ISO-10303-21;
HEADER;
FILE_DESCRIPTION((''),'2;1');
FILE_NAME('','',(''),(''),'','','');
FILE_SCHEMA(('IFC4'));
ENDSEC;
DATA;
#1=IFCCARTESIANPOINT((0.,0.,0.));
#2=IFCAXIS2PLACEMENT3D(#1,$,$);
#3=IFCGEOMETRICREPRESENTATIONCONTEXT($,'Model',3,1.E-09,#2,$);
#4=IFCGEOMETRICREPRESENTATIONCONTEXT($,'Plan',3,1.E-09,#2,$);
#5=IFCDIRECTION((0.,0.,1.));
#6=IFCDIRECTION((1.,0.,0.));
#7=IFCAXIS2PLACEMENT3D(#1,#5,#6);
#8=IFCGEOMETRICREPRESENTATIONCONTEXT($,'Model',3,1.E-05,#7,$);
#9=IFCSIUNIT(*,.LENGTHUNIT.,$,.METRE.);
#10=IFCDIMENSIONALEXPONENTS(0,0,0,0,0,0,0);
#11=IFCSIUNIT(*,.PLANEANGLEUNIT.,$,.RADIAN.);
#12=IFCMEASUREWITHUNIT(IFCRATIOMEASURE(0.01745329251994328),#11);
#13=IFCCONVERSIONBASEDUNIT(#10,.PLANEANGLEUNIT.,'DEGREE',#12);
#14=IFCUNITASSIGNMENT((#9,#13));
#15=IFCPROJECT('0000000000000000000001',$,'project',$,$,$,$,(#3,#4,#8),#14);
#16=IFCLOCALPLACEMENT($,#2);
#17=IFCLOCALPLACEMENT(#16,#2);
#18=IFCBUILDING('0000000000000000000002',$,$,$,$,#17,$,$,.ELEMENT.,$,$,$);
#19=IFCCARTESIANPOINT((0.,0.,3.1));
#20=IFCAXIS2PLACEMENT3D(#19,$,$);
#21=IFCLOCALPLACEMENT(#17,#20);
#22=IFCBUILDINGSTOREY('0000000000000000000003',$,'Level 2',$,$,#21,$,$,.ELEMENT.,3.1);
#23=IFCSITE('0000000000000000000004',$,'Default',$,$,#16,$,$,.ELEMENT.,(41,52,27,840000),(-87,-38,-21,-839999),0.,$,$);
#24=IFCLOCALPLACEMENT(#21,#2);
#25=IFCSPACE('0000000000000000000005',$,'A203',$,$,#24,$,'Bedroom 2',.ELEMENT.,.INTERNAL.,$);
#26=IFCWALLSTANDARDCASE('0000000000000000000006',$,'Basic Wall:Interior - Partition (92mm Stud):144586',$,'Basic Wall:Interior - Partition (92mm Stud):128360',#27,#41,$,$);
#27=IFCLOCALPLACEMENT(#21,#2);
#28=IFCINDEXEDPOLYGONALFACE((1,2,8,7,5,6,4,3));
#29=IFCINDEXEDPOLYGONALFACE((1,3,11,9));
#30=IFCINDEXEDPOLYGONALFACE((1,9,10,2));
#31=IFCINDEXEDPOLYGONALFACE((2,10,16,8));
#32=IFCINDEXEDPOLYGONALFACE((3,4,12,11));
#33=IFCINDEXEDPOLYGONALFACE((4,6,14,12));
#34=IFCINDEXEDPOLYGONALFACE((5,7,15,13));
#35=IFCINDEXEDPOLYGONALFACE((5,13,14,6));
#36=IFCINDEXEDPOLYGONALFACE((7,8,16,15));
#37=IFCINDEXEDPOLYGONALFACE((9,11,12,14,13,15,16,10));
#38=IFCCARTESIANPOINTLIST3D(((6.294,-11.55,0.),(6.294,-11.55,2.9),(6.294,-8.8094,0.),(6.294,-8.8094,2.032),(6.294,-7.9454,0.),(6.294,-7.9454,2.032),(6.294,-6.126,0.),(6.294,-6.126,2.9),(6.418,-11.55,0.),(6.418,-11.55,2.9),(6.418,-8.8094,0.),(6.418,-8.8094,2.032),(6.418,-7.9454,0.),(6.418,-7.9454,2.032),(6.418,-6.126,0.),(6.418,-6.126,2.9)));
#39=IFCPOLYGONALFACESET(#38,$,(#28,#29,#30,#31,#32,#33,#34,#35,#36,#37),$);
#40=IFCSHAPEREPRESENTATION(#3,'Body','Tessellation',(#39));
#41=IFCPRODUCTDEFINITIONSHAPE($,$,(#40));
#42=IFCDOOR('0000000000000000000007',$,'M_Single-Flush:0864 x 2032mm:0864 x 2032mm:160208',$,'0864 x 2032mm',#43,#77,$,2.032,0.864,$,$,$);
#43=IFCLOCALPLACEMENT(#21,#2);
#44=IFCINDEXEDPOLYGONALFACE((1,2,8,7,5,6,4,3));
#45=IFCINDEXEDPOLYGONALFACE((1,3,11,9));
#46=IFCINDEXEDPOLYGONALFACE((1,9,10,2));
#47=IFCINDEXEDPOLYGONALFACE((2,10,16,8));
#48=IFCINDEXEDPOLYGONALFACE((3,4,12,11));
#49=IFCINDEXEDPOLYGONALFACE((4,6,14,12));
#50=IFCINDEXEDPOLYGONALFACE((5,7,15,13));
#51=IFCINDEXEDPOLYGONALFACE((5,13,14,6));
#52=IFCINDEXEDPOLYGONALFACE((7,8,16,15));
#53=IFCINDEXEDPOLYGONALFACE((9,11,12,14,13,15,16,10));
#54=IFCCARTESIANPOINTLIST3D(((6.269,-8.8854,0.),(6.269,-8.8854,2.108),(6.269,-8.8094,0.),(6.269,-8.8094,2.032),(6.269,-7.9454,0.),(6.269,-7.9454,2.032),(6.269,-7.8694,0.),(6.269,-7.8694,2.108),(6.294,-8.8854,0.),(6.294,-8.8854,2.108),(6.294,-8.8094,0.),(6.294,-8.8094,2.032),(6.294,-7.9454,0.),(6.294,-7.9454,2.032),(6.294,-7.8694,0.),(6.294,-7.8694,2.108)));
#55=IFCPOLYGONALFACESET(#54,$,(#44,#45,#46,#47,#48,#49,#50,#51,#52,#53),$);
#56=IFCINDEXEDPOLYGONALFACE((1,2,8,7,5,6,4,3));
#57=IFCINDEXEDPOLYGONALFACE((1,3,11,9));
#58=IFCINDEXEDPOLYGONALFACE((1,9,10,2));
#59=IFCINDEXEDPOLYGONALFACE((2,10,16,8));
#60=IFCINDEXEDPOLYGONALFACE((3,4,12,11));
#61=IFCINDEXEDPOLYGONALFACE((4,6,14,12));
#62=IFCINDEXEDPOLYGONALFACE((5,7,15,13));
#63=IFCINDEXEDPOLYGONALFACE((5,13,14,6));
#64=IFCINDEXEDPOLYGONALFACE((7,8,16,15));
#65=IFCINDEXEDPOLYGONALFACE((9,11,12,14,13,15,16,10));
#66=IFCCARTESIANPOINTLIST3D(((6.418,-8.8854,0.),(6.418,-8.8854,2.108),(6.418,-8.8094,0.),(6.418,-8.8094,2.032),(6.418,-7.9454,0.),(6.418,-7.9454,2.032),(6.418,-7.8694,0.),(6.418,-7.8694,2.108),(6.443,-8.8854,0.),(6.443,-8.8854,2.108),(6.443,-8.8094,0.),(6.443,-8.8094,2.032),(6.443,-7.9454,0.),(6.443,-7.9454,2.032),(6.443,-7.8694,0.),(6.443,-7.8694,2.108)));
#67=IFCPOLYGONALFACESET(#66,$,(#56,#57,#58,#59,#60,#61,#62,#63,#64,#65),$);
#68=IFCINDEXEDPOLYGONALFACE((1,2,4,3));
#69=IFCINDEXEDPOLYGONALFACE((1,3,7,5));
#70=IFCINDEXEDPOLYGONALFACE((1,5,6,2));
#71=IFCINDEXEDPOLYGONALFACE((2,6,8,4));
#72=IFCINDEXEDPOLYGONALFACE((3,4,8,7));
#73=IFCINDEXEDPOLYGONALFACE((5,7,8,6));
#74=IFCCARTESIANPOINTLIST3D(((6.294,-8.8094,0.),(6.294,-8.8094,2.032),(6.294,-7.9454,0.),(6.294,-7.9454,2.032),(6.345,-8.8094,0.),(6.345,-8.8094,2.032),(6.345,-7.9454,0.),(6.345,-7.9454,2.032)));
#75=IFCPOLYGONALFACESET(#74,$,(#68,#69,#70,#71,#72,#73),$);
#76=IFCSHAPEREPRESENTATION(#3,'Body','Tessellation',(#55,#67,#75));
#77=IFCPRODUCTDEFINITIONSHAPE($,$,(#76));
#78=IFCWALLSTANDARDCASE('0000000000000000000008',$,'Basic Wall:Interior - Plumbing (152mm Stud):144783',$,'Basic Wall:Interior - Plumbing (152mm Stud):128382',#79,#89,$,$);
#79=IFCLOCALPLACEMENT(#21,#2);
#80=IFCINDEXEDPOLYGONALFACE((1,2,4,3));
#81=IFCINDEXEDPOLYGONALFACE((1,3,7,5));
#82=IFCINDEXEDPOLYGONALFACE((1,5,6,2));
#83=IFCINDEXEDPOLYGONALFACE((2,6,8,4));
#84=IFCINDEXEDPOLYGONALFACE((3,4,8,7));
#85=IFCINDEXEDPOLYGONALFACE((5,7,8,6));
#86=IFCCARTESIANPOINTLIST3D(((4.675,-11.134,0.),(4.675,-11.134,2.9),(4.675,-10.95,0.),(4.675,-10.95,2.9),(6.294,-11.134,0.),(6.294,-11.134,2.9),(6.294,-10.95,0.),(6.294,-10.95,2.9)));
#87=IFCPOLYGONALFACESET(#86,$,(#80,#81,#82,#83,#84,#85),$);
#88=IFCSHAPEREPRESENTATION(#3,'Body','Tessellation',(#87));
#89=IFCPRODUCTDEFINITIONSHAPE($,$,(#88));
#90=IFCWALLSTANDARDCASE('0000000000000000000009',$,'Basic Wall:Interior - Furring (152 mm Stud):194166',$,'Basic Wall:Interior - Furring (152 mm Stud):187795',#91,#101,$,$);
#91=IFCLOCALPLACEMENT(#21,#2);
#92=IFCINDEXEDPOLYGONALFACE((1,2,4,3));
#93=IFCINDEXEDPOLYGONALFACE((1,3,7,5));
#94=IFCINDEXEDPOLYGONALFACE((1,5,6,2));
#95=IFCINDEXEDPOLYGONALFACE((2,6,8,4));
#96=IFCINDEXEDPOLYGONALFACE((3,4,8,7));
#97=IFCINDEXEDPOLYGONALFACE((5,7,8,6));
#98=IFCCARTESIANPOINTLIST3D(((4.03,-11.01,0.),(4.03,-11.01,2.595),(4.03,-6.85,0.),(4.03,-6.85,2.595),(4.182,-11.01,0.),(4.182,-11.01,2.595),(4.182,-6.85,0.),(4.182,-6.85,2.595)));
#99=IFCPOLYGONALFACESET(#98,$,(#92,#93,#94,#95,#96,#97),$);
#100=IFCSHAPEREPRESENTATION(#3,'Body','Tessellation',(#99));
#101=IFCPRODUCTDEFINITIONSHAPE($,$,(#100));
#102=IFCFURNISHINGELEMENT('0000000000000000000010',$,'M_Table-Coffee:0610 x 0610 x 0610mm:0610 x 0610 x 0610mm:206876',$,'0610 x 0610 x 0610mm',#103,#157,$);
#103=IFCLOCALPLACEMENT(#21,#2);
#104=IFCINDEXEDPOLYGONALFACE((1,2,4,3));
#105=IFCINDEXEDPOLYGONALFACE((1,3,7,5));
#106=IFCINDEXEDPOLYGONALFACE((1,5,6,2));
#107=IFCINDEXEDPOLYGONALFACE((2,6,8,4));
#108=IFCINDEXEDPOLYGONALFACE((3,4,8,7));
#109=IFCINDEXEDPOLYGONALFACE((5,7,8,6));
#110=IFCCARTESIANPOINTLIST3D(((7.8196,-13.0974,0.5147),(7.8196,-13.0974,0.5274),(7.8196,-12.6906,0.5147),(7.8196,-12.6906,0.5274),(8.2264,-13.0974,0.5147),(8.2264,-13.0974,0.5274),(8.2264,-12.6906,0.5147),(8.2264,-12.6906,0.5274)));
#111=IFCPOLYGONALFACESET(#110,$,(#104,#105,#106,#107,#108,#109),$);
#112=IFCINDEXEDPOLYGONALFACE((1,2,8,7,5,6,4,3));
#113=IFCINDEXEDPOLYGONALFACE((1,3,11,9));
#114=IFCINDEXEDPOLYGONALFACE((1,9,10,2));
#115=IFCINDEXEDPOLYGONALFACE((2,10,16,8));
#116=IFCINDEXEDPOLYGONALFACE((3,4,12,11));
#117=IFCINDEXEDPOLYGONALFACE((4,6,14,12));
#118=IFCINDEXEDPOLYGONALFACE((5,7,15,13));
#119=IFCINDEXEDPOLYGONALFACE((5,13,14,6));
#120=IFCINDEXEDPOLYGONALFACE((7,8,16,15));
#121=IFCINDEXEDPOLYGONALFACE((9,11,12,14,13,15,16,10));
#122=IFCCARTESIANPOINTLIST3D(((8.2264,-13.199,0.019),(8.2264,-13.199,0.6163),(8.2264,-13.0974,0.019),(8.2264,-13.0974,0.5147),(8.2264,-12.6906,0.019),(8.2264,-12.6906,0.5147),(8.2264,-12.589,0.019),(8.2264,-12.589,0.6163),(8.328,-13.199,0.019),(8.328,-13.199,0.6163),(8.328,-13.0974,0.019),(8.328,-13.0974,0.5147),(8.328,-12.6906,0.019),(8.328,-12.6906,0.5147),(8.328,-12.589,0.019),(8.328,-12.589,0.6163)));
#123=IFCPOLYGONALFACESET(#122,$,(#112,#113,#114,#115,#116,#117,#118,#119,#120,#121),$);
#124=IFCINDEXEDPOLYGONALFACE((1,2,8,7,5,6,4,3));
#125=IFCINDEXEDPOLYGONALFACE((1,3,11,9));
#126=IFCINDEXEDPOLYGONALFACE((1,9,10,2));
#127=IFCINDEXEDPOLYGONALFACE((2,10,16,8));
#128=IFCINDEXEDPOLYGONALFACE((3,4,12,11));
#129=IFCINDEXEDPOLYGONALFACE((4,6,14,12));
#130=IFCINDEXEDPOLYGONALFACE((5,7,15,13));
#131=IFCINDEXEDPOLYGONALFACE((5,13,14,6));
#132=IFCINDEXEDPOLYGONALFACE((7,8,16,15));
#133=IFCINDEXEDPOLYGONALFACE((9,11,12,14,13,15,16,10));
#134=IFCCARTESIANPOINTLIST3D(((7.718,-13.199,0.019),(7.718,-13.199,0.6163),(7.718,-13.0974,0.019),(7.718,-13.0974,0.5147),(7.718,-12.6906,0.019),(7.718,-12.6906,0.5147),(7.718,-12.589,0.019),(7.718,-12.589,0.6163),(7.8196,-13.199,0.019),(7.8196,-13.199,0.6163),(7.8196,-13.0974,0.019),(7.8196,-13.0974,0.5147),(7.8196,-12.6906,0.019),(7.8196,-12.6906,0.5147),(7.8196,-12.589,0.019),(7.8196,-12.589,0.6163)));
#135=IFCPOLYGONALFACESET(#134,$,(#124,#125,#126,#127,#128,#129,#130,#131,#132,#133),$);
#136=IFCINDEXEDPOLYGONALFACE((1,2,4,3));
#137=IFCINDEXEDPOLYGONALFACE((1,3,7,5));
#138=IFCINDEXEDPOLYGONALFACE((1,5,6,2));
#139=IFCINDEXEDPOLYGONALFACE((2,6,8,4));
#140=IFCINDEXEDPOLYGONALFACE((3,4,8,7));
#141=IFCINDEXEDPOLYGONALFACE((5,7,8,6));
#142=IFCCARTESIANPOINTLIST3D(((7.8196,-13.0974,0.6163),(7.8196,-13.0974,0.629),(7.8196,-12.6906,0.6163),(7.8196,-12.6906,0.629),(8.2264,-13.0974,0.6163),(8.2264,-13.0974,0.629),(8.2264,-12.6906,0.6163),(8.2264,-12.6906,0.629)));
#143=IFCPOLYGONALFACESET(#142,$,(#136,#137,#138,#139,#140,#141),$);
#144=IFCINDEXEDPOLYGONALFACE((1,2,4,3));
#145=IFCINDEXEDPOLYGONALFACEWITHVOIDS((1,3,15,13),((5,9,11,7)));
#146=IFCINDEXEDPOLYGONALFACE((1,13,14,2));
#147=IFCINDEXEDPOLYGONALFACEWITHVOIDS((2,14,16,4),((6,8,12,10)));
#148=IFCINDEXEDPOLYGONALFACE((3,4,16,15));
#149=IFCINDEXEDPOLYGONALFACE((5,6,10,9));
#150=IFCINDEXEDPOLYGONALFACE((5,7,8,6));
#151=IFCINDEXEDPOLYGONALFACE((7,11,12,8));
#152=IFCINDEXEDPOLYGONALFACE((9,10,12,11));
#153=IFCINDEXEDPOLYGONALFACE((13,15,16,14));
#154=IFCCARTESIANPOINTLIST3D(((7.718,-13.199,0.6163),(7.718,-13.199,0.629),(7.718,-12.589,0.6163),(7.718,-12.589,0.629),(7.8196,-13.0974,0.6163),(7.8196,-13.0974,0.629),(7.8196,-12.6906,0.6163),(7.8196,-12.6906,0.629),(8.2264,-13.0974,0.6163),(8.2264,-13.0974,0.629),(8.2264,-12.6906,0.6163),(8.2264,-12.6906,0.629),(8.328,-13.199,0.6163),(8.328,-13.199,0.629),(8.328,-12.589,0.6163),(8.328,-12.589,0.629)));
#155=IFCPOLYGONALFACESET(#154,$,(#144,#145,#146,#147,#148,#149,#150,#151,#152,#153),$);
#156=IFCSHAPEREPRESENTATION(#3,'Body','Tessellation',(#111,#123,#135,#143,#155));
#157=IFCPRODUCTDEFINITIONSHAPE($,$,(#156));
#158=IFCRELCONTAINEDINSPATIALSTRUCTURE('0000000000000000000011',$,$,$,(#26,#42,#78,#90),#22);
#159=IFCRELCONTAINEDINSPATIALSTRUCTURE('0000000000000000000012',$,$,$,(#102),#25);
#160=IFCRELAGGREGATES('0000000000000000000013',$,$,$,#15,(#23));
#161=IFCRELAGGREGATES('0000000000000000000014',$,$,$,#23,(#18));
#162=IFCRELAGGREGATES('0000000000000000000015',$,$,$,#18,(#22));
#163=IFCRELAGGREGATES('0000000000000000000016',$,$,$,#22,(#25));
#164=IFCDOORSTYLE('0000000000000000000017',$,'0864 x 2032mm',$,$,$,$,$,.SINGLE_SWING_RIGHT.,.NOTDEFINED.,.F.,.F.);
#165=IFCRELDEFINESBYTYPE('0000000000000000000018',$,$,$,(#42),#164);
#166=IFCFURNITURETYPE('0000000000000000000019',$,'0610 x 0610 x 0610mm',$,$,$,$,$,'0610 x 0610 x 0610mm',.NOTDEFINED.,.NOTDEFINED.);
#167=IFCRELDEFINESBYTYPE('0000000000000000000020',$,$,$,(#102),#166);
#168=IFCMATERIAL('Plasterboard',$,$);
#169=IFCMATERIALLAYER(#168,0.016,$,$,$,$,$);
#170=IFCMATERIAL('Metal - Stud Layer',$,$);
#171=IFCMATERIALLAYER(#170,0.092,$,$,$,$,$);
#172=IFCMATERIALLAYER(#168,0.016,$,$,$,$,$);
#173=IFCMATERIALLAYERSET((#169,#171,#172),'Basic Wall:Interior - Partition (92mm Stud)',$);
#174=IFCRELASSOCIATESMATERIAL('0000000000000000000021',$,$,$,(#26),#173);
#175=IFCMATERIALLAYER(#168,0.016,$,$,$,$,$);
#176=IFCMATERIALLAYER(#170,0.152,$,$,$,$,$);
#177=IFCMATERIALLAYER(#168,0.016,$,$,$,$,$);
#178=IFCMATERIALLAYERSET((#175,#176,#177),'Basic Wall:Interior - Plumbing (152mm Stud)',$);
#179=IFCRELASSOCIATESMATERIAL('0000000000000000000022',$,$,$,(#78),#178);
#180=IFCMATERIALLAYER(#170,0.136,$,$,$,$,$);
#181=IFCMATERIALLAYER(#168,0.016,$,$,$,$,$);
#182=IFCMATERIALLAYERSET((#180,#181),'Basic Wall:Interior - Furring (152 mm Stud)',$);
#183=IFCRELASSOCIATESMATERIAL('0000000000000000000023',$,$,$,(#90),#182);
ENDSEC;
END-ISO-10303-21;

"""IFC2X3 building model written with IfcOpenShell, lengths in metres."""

from ifc_helpers import new_model, entity, si_unit, converted_unit, frame, frame_2d, origin, origin_with_axes, origin_2d_with_axis, place, context, project, spatial, polyline, rectangle, outline, extrude, source, transform, mapped, material, layer, layer_set, layer_usage, type_object, type_shapes, element, fill, save


model = new_model("IFC2X3")

# Units and contexts
model_context_1 = context("Model", 3, precision=1e-09, world=origin())
plan_context = context("Plan", 3, precision=1e-09, world=origin())
model_context_2 = context("Model", 3, precision=1e-05, world=origin_with_axes())
ifc_project = project(units=[si_unit("LENGTHUNIT", "METRE"), converted_unit("PLANEANGLEUNIT", "DEGREE", entity("IfcRatioMeasure", 0.01745329251994328), si_unit("PLANEANGLEUNIT", "RADIAN"), dimensions=[0, 0, 0, 0, 0, 0, 0])], contexts=[model_context_1, plan_context, model_context_2])

# Site, building, storey
site_placement = place(None, origin())
site = spatial("IfcSite", under=ifc_project, at=site_placement, Name="Default", CompositionType="ELEMENT", RefLatitude=(41, 52, 27, 840000), RefLongitude=(-87, -38, -21, -839999), RefElevation=0.0)
building_placement = place(site_placement, origin())
building = spatial("IfcBuilding", under=site, at=building_placement, CompositionType="ELEMENT")
storey_placement = place(building_placement, frame((0.0, 0.0, 3.1)))
storey = spatial("IfcBuildingStorey", under=building, at=storey_placement, Name="Level 2", CompositionType="ELEMENT", Elevation=3.1)

# Shared definitions
ifc_material_1 = material(Name="Metal - Stud Layer")
ifc_material_2 = material(Name="Plasterboard")

# Shared definitions
ifc_layer_1 = layer(ifc_material_2, 0.016)
ifc_layer_2 = layer(ifc_material_1, 0.092)
ifc_layer_3 = layer(ifc_material_2, 0.016)
ifc_layer_set_1 = layer_set([ifc_layer_1, ifc_layer_2, ifc_layer_3], Name="Basic Wall:Interior - Partition (92mm Stud)")

# Wall, opening, door
ifc_layer_usage_1 = layer_usage(ifc_layer_set_1, "AXIS2", "NEGATIVE", 0.062)
wall_1_placement = place(storey_placement, frame((6.356, -11.55, 0.0), z_axis=(0.0, 0.0, 1.0), x_axis=(0.0, 1.0, 0.0)))
wall_1 = element("IfcWallStandardCase", 1, at=wall_1_placement, inside=storey, material=ifc_layer_usage_1, Name="Basic Wall:Interior - Partition (92mm Stud):144586", ObjectType="Basic Wall:Interior - Partition (92mm Stud):128360", context=model_context_1, shape_type="SweptSolid", body=[
    extrude(rectangle(XDim=5.424, YDim=0.124, at=frame_2d((2.712, 0.0), x_axis=(-1.0, 0.0))), origin(), (0.0, 0.0, 1.0), 2.9),
])
opening_1_placement = place(wall_1_placement, frame((2.7406, -0.062, 0.0)))
opening_1 = element("IfcOpeningElement", 2, at=opening_1_placement, cuts=wall_1, ObjectType="Opening", context=model_context_1, shape_type="SweptSolid", body=[
    extrude(rectangle(XDim=0.864, YDim=2.032, at=frame_2d((1.016, 0.432), x_axis=(0.0, 1.0))), frame((0.0, 0.0, 0.0), z_axis=(0.0, 1.0, 0.0), x_axis=(0.0, 0.0, 1.0)), (0.0, 0.0, 1.0), 0.124),
])
door_style = type_object("IfcDoorStyle", Name="0864 x 2032mm", ConstructionType="NOTDEFINED", OperationType="SINGLE_SWING_RIGHT", ParameterTakesPrecedence=False, Sizeable=False)
shared_shape_1 = source(origin(), model_context_1, "Body", "SweptSolid", [
    extrude(outline(polyline([(-0.508, -1.073), (0.508, -1.073), (0.508, 1.035), (0.432, 1.035), (0.432, -0.997), (-0.432, -0.997), (-0.432, 1.035), (-0.508, 1.035), (-0.508, -1.073)])), frame((0.432, 0.124, 1.035), z_axis=(0.0, 1.0, 0.0), x_axis=(1.0, 0.0, 0.0)), (0.0, 0.0, 1.0), 0.025),
    extrude(outline(polyline([(-1.073, -0.508), (1.035, -0.508), (1.035, -0.432), (-0.997, -0.432), (-0.997, 0.432), (1.035, 0.432), (1.035, 0.508), (-1.073, 0.508), (-1.073, -0.508)])), frame((0.432, -0.025, 1.035), z_axis=(0.0, 1.0, 0.0), x_axis=(0.0, 0.0, -1.0)), (0.0, 0.0, 1.0), 0.025),
    extrude(rectangle(XDim=0.051, YDim=0.864, at=origin_2d_with_axis()), frame((0.432, 0.0985, 0.0), z_axis=(0.0, 0.0, 1.0), x_axis=(0.0, 1.0, 0.0)), (0.0, 0.0, 1.0), 2.032),
])
type_shapes(door_style, [shared_shape_1])
door_placement = place(opening_1_placement, origin())
door = element("IfcDoor", 3, at=door_placement, inside=storey, type_object=door_style, Name="M_Single-Flush:0864 x 2032mm:0864 x 2032mm:160208", ObjectType="0864 x 2032mm", OverallHeight=2.032, OverallWidth=0.864, context=model_context_1, shape_type="MappedRepresentation", body=[
    mapped(shared_shape_1, transform((0.0, 0.0, 0.0), scale=1.0)),
])
fill(opening_1, door)

# Walls
ifc_layer_4 = layer(ifc_material_2, 0.016)
ifc_layer_5 = layer(ifc_material_1, 0.152)
ifc_layer_6 = layer(ifc_material_2, 0.016)
ifc_layer_set_2 = layer_set([ifc_layer_4, ifc_layer_5, ifc_layer_6], Name="Basic Wall:Interior - Plumbing (152mm Stud)")
ifc_layer_usage_2 = layer_usage(ifc_layer_set_2, "AXIS2", "NEGATIVE", 0.092)
wall_2_placement = place(storey_placement, frame((6.294, -11.042, 0.0), z_axis=(0.0, 0.0, 1.0), x_axis=(-1.0, 0.0, 0.0)))
element("IfcWallStandardCase", 4, at=wall_2_placement, inside=storey, material=ifc_layer_usage_2, Name="Basic Wall:Interior - Plumbing (152mm Stud):144783", ObjectType="Basic Wall:Interior - Plumbing (152mm Stud):128382", context=model_context_1, shape_type="SweptSolid", body=[
    extrude(rectangle(XDim=1.619, YDim=0.184, at=frame_2d((0.8095, 0.0), x_axis=(-1.0, 0.0))), origin(), (0.0, 0.0, 1.0), 2.9),
])
ifc_layer_7 = layer(ifc_material_1, 0.136)
ifc_layer_8 = layer(ifc_material_2, 0.016)
ifc_layer_set_3 = layer_set([ifc_layer_7, ifc_layer_8], Name="Basic Wall:Interior - Furring (152 mm Stud)")
ifc_layer_usage_3 = layer_usage(ifc_layer_set_3, "AXIS2", "POSITIVE", -0.076)
wall_3_placement = place(storey_placement, frame((4.106, -11.01, 0.0), z_axis=(0.0, 0.0, 1.0), x_axis=(0.0, 1.0, 0.0)))
element("IfcWallStandardCase", 5, at=wall_3_placement, inside=storey, material=ifc_layer_usage_3, Name="Basic Wall:Interior - Furring (152 mm Stud):194166", ObjectType="Basic Wall:Interior - Furring (152 mm Stud):187795", context=model_context_1, shape_type="SweptSolid", body=[
    extrude(rectangle(XDim=4.16, YDim=0.152, at=frame_2d((2.08, 0.0), x_axis=(-1.0, 0.0))), origin(), (0.0, 0.0, 1.0), 2.595),
])

# Shared definitions
space_placement = place(storey_placement, origin())
space = spatial("IfcSpace", under=storey, at=space_placement, Name="A203", LongName="Bedroom 2", CompositionType="ELEMENT", InteriorOrExteriorSpace="INTERNAL")

# Furnishing element
furniture_type = type_object("IfcFurnitureType", Name="0610 x 0610 x 0610mm", ElementType="0610 x 0610 x 0610mm", AssemblyPlace="NOTDEFINED")
shared_shape_2 = source(origin(), model_context_1, "Body", "SweptSolid", [
    extrude(rectangle(XDim=0.4068, YDim=0.4068, at=origin_2d_with_axis()), frame((0.0183, 0.0952, 0.4957), z_axis=(0.0, 0.0, 1.0), x_axis=(-1.0, 0.0, 0.0)), (0.0, 0.0, 1.0), 0.0127),
    extrude(outline(polyline([(-0.2732, -0.305), (0.324, -0.305), (0.324, 0.305), (-0.2732, 0.305), (-0.2732, 0.2034), (0.2225, 0.2034), (0.2225, -0.2034), (-0.2732, -0.2034), (-0.2732, -0.305)])), frame((0.2217, 0.0952, 0.2732), z_axis=(1.0, 0.0, 0.0), x_axis=(0.0, 0.0, 1.0)), (0.0, 0.0, 1.0), 0.1016),
    extrude(outline(polyline([(-0.305, -0.3241), (0.305, -0.3241), (0.305, 0.2733), (0.2034, 0.2733), (0.2034, -0.2224), (-0.2034, -0.2224), (-0.2034, 0.2733), (-0.305, 0.2733), (-0.305, -0.3241)])), frame((-0.2867, 0.0952, 0.2733), z_axis=(1.0, 0.0, 0.0), x_axis=(0.0, -1.0, 0.0)), (0.0, 0.0, 1.0), 0.1016),
    extrude(rectangle(XDim=0.4068, YDim=0.4068, at=origin_2d_with_axis()), frame((0.0183, 0.0952, 0.5973), z_axis=(0.0, 0.0, 1.0), x_axis=(-1.0, 0.0, 0.0)), (0.0, 0.0, 1.0), 0.0127),
    extrude(outline(polyline([(-0.305, -0.305), (0.305, -0.305), (0.305, 0.305), (-0.305, 0.305), (-0.305, -0.305)]), holes=[polyline([(-0.2034, -0.2034), (-0.2034, 0.2034), (0.2034, 0.2034), (0.2034, -0.2034), (-0.2034, -0.2034)])]), frame((0.0183, 0.0952, 0.5973), z_axis=(0.0, 0.0, 1.0), x_axis=(-1.0, 0.0, 0.0)), (0.0, 0.0, 1.0), 0.0127),
])
type_shapes(furniture_type, [shared_shape_2])
furnishing_placement = place(space_placement, frame((8.0047, -12.9892, 0.019)))
element("IfcFurnishingElement", 6, at=furnishing_placement, inside=space, type_object=furniture_type, Name="M_Table-Coffee:0610 x 0610 x 0610mm:0610 x 0610 x 0610mm:206876", ObjectType="0610 x 0610 x 0610mm", context=model_context_1, shape_type="MappedRepresentation", body=[
    mapped(shared_shape_2, transform((0.0, 0.0, 0.0), scale=1.0)),
])

save(model, "model.ifc")
